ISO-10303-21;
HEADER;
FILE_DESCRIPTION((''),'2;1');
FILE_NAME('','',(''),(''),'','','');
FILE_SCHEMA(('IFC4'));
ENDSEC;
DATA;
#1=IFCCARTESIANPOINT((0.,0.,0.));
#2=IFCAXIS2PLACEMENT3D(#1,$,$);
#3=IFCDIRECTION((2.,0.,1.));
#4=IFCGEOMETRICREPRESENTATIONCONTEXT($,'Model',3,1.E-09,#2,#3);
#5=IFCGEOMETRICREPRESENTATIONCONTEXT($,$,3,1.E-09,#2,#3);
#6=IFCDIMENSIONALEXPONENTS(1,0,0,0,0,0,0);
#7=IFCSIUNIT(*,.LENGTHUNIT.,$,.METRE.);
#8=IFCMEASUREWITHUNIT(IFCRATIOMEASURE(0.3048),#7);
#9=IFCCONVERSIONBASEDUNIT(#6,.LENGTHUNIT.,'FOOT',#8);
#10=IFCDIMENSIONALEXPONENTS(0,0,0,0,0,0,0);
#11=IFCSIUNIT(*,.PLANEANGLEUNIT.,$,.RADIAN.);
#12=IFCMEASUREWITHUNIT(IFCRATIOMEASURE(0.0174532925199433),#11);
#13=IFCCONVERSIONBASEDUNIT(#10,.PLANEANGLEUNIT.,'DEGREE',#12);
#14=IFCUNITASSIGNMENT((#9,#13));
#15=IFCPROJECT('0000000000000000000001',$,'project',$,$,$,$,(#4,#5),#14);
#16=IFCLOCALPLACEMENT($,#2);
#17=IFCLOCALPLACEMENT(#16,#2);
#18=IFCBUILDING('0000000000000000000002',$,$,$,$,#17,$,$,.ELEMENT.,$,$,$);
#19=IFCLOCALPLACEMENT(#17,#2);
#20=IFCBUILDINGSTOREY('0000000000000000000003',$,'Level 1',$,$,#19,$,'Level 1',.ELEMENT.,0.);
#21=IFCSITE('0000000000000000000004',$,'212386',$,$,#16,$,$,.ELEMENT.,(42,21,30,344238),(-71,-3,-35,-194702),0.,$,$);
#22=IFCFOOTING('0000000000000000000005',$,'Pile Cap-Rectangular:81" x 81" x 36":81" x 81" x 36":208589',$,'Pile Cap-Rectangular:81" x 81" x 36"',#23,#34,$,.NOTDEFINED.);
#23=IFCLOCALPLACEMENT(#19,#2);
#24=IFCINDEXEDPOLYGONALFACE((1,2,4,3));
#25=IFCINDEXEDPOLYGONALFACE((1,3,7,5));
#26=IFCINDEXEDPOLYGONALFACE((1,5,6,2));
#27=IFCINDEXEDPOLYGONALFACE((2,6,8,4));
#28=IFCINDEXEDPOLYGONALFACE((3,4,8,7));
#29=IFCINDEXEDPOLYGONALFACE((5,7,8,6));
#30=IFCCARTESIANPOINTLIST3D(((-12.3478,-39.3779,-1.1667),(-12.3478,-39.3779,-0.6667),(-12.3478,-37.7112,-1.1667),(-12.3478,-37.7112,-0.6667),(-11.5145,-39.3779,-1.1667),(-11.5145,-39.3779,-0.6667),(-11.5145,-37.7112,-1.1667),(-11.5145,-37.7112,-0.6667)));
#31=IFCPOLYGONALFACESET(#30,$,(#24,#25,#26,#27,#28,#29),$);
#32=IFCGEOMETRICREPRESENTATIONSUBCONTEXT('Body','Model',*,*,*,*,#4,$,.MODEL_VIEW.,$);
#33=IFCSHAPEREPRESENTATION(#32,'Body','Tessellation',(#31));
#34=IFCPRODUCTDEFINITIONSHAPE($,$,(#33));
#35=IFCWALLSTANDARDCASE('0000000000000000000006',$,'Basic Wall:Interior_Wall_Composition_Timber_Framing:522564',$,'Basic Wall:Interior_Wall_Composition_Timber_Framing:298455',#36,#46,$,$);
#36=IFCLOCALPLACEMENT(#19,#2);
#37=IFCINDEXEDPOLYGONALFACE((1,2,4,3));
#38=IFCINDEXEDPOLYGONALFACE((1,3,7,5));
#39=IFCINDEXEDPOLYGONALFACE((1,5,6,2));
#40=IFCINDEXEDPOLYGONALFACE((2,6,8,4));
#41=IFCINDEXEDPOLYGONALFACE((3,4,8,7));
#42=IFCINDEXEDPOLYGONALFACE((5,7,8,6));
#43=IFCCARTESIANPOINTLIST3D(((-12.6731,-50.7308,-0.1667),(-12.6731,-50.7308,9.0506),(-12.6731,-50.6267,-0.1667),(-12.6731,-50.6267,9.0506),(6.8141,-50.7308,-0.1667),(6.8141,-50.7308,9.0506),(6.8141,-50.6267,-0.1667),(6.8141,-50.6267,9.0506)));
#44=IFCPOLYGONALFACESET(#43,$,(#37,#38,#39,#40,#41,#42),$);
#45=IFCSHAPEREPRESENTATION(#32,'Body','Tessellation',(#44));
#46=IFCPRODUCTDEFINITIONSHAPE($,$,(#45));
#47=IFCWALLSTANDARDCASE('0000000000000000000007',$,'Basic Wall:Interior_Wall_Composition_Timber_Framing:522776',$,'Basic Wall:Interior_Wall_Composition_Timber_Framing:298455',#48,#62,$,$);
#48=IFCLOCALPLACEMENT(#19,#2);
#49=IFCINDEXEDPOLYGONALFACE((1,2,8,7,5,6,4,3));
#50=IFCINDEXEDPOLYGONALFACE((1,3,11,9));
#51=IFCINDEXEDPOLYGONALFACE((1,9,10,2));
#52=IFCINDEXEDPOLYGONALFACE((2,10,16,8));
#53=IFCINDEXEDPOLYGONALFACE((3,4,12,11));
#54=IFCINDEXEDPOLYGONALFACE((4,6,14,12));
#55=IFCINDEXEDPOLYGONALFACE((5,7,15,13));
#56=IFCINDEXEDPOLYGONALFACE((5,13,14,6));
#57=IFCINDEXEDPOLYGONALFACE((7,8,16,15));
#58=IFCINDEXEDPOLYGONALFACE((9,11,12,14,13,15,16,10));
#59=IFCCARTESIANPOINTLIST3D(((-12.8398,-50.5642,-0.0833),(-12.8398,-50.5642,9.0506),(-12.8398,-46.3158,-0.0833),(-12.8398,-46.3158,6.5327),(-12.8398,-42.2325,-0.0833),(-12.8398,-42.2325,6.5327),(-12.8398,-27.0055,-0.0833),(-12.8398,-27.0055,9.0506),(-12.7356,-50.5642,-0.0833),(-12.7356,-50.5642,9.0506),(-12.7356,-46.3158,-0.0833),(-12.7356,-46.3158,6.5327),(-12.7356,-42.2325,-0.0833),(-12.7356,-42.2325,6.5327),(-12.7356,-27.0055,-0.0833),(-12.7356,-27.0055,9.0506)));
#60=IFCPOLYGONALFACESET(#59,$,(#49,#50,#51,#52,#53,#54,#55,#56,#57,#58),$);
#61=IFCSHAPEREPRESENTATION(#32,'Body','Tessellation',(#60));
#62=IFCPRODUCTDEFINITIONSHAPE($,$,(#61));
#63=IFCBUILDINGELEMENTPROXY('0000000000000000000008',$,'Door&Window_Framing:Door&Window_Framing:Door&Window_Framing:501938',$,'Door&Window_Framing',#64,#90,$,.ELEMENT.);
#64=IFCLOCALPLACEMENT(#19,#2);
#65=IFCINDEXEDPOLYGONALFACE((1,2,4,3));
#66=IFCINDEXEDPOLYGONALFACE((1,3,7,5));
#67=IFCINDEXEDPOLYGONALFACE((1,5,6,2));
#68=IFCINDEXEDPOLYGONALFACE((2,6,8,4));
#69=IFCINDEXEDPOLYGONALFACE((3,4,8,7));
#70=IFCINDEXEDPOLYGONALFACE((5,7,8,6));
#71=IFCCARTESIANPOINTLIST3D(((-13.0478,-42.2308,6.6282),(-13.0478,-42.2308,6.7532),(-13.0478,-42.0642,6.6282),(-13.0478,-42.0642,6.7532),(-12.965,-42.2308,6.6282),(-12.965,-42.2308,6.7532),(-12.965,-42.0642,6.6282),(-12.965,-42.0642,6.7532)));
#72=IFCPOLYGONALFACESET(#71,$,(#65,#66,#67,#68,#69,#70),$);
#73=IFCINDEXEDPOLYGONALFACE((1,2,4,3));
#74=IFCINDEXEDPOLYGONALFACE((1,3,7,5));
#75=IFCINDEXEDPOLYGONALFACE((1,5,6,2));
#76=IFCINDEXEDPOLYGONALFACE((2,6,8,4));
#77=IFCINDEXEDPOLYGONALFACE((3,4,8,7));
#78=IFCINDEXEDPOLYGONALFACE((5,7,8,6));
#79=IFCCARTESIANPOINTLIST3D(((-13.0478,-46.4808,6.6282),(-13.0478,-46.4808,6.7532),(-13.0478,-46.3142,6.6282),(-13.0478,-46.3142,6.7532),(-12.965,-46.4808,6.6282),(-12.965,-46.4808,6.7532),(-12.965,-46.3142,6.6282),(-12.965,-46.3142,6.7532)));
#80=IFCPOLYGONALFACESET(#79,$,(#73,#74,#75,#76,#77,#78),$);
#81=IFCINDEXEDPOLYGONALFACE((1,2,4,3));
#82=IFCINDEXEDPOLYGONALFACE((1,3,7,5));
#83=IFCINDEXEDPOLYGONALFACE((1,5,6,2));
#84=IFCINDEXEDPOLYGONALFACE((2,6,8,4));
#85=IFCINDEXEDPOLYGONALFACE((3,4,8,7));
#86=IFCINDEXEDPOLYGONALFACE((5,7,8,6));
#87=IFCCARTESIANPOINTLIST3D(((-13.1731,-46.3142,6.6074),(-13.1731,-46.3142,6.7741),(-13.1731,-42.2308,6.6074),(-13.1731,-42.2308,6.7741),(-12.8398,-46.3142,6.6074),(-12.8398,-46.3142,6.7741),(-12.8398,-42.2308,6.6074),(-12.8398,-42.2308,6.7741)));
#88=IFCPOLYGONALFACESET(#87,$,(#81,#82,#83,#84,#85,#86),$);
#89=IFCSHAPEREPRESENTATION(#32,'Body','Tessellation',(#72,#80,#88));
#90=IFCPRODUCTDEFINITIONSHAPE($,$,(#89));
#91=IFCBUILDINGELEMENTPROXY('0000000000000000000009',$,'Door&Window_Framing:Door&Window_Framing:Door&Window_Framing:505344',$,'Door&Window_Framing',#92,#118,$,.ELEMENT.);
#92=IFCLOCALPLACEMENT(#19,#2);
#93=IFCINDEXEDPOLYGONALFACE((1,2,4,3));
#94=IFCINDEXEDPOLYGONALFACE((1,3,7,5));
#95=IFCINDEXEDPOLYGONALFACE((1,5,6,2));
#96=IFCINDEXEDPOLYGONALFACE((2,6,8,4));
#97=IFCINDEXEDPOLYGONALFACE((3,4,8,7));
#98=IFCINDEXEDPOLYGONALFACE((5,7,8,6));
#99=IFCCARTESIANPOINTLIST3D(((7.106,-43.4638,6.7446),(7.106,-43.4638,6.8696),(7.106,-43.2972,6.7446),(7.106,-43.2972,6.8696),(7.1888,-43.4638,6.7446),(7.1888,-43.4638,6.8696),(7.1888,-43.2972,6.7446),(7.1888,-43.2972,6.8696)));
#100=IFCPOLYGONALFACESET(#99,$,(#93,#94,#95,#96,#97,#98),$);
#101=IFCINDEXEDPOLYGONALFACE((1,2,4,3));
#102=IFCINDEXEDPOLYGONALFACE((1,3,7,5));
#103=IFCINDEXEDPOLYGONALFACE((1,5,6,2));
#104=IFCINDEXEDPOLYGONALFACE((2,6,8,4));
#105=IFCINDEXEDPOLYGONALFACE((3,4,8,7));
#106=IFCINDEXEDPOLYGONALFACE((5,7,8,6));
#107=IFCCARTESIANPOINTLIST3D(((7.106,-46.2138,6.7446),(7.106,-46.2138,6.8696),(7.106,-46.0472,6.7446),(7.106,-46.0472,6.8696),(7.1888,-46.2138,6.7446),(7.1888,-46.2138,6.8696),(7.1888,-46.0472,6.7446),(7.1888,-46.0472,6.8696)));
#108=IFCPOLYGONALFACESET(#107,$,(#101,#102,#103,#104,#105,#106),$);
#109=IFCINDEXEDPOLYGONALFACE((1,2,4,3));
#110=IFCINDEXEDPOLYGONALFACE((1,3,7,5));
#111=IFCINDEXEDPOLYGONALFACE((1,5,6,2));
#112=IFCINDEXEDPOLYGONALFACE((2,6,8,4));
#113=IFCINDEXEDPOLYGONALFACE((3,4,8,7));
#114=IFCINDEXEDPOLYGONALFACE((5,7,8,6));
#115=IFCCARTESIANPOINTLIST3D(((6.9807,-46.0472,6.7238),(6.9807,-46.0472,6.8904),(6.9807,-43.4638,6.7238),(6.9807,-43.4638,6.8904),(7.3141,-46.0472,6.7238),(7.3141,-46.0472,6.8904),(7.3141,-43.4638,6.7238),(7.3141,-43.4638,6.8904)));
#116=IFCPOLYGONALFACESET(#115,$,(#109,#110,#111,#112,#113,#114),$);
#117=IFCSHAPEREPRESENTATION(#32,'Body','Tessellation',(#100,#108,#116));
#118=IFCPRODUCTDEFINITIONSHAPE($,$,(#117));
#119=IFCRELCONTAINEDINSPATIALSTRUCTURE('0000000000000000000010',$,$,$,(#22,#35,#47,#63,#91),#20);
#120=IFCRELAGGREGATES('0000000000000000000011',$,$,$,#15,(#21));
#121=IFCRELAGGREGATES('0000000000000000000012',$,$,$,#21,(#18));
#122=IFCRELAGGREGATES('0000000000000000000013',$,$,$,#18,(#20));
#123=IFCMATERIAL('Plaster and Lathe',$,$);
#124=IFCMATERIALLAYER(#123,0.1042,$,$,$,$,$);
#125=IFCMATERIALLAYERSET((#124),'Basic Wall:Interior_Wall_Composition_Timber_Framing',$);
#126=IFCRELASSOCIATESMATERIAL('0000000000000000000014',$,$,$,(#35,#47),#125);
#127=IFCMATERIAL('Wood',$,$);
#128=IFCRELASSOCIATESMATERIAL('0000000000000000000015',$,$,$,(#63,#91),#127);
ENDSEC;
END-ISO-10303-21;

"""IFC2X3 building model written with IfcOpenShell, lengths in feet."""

from ifc_helpers import new_model, entity, si_unit, converted_unit, direction, frame, frame_2d, origin, origin_2d_with_axis, place, context, subcontext, project, spatial, rectangle, extrude, source, transform, mapped, material, layer, layer_set, layer_usage, element, save


model = new_model("IFC2X3")

# Units and contexts
model_context = context("Model", 3, precision=1e-09, world=origin(), true_north=direction((2.0, 0.0, 1.0)))
context_of_model = context(None, 3, precision=1e-09, world=origin(), true_north=direction((2.0, 0.0, 1.0)))
body_context = subcontext(model_context, "Body", "Model", "MODEL_VIEW")
ifc_project = project(units=[converted_unit("LENGTHUNIT", "FOOT", entity("IfcRatioMeasure", 0.3048), si_unit("LENGTHUNIT", "METRE"), dimensions=[1, 0, 0, 0, 0, 0, 0]), converted_unit("PLANEANGLEUNIT", "DEGREE", entity("IfcRatioMeasure", 0.0174532925199433), si_unit("PLANEANGLEUNIT", "RADIAN"), dimensions=[0, 0, 0, 0, 0, 0, 0])], contexts=[model_context, context_of_model])

# Site, building, storey
site_placement = place(None, origin())
site = spatial("IfcSite", under=ifc_project, at=site_placement, Name="212386", CompositionType="ELEMENT", RefLatitude=(42, 21, 30, 344238), RefLongitude=(-71, -3, -35, -194702), RefElevation=0.0)
building_placement = place(site_placement, origin())
building = spatial("IfcBuilding", under=site, at=building_placement, CompositionType="ELEMENT")
storey_placement = place(building_placement, origin())
storey = spatial("IfcBuildingStorey", under=building, at=storey_placement, Name="Level 1", LongName="Level 1", CompositionType="ELEMENT", Elevation=0.0)

# Footing
footing_1_placement = place(storey_placement, origin())
element("IfcFooting", 1, at=footing_1_placement, inside=storey, Name="Pile Cap-Rectangular:81\" x 81\" x 36\":81\" x 81\" x 36\":208589", ObjectType="Pile Cap-Rectangular:81\" x 81\" x 36\"", PredefinedType="NOTDEFINED", context=body_context, shape_type="SweptSolid", body=[
    extrude(rectangle(XDim=0.8333, YDim=1.6667, at=frame_2d((0.0, 0.0), x_axis=(1.0, 0.0))), frame((-11.9311, -38.5446, -1.1667), z_axis=(0.0, 0.0, 1.0), x_axis=(-1.0, 0.0, 0.0)), (0.0, 0.0, 1.0), 0.5),
])

# Wall
ifc_material_1 = material(Name="Plaster and Lathe")
ifc_layer = layer(ifc_material_1, 0.1042)
ifc_layer_set = layer_set([ifc_layer], Name="Basic Wall:Interior_Wall_Composition_Timber_Framing")
ifc_layer_usage_1 = layer_usage(ifc_layer_set, "AXIS2", "NEGATIVE", 0.0521)
wall_1_placement = place(storey_placement, frame((-12.6731, -50.6788, -0.1667)))
element("IfcWallStandardCase", 2, at=wall_1_placement, inside=storey, material=ifc_layer_usage_1, Name="Basic Wall:Interior_Wall_Composition_Timber_Framing:522564", ObjectType="Basic Wall:Interior_Wall_Composition_Timber_Framing:298455", context=body_context, shape_type="SweptSolid", body=[
    extrude(rectangle(XDim=19.4872, YDim=0.1042, at=frame_2d((9.7436, 0.0), x_axis=(-1.0, 0.0))), origin(), (0.0, 0.0, 1.0), 9.2173),
])

# Wall, opening
ifc_layer_usage_2 = layer_usage(ifc_layer_set, "AXIS2", "NEGATIVE", 0.0521)
wall_2_placement = place(storey_placement, frame((-12.7877, -50.5642, -0.0833), z_axis=(0.0, 0.0, 1.0), x_axis=(0.0, 1.0, 0.0)))
wall_2 = element("IfcWallStandardCase", 3, at=wall_2_placement, inside=storey, material=ifc_layer_usage_2, Name="Basic Wall:Interior_Wall_Composition_Timber_Framing:522776", ObjectType="Basic Wall:Interior_Wall_Composition_Timber_Framing:298455", context=body_context, shape_type="SweptSolid", body=[
    extrude(rectangle(XDim=23.5587, YDim=0.1042, at=frame_2d((11.7794, 0.0), x_axis=(-1.0, 0.0))), origin(), (0.0, 0.0, 1.0), 9.1339),
])
opening_placement = place(wall_2_placement, origin())
element("IfcOpeningElement", 4, at=opening_placement, cuts=wall_2, ObjectType="Opening", context=body_context, shape_type="SweptSolid", body=[
    extrude(rectangle(XDim=6.9494, YDim=4.0833, at=origin_2d_with_axis()), frame((6.29, -0.0521, 3.1413), z_axis=(0.0, 1.0, 0.0), x_axis=(0.0, 0.0, -1.0)), (0.0, 0.0, 1.0), 0.1042),
])

# Building element proxies
ifc_material_2 = material(Name="Wood")
shared_shape_1 = source(origin(), body_context, "Body", "SweptSolid", [
    extrude(rectangle(XDim=0.1667, YDim=0.0828, at=origin_2d_with_axis()), frame((2.125, 0.0, -0.0625), z_axis=(0.0, 0.0, 1.0), x_axis=(-1.0, 0.0, 0.0)), (0.0, 0.0, 1.0), 0.125),
    extrude(rectangle(XDim=0.1667, YDim=0.0828, at=origin_2d_with_axis()), frame((-2.125, 0.0, -0.0625)), (0.0, 0.0, 1.0), 0.125),
    extrude(rectangle(XDim=4.0833, YDim=0.3333, at=origin_2d_with_axis()), frame((0.0, 0.0, -0.0833), z_axis=(0.0, 0.0, 1.0), x_axis=(-1.0, 0.0, 0.0)), (0.0, 0.0, 1.0), 0.1667),
])
proxy_1_placement = place(storey_placement, frame((-13.0064, -44.2725, 6.6907), z_axis=(0.0, 0.0, 1.0), x_axis=(0.0, 1.0, 0.0)))
element("IfcBuildingElementProxy", 5, at=proxy_1_placement, inside=storey, material=ifc_material_2, Name="Door&Window_Framing:Door&Window_Framing:Door&Window_Framing:501938", ObjectType="Door&Window_Framing", CompositionType="ELEMENT", context=body_context, shape_type="MappedRepresentation", body=[
    mapped(shared_shape_1, transform((0.0, 0.0, 0.0), scale=1.0)),
])
shared_shape_2 = source(origin(), body_context, "Body", "SweptSolid", [
    extrude(rectangle(XDim=0.0828, YDim=0.1667, at=origin_2d_with_axis()), frame((1.375, 0.0, -0.0625), z_axis=(0.0, 0.0, 1.0), x_axis=(0.0, 1.0, 0.0)), (0.0, 0.0, 1.0), 0.125),
    extrude(rectangle(XDim=0.0828, YDim=0.1667, at=origin_2d_with_axis()), frame((-1.375, 0.0, -0.0625), z_axis=(0.0, 0.0, 1.0), x_axis=(0.0, -1.0, 0.0)), (0.0, 0.0, 1.0), 0.125),
    extrude(rectangle(XDim=0.3333, YDim=2.5833, at=frame_2d((0.0, 0.0), x_axis=(1.0, 0.0))), frame((0.0, 0.0, -0.0833), z_axis=(0.0, 0.0, 1.0), x_axis=(0.0, 1.0, 0.0)), (0.0, 0.0, 1.0), 0.1667),
])
proxy_2_placement = place(storey_placement, frame((7.1474, -44.7555, 6.8071), z_axis=(0.0, 0.0, 1.0), x_axis=(0.0, 1.0, 0.0)))
element("IfcBuildingElementProxy", 6, at=proxy_2_placement, inside=storey, material=ifc_material_2, Name="Door&Window_Framing:Door&Window_Framing:Door&Window_Framing:505344", ObjectType="Door&Window_Framing", CompositionType="ELEMENT", context=body_context, shape_type="MappedRepresentation", body=[
    mapped(shared_shape_2, transform((0.0, 0.0, 0.0), scale=1.0)),
])

save(model, "model.ifc")
